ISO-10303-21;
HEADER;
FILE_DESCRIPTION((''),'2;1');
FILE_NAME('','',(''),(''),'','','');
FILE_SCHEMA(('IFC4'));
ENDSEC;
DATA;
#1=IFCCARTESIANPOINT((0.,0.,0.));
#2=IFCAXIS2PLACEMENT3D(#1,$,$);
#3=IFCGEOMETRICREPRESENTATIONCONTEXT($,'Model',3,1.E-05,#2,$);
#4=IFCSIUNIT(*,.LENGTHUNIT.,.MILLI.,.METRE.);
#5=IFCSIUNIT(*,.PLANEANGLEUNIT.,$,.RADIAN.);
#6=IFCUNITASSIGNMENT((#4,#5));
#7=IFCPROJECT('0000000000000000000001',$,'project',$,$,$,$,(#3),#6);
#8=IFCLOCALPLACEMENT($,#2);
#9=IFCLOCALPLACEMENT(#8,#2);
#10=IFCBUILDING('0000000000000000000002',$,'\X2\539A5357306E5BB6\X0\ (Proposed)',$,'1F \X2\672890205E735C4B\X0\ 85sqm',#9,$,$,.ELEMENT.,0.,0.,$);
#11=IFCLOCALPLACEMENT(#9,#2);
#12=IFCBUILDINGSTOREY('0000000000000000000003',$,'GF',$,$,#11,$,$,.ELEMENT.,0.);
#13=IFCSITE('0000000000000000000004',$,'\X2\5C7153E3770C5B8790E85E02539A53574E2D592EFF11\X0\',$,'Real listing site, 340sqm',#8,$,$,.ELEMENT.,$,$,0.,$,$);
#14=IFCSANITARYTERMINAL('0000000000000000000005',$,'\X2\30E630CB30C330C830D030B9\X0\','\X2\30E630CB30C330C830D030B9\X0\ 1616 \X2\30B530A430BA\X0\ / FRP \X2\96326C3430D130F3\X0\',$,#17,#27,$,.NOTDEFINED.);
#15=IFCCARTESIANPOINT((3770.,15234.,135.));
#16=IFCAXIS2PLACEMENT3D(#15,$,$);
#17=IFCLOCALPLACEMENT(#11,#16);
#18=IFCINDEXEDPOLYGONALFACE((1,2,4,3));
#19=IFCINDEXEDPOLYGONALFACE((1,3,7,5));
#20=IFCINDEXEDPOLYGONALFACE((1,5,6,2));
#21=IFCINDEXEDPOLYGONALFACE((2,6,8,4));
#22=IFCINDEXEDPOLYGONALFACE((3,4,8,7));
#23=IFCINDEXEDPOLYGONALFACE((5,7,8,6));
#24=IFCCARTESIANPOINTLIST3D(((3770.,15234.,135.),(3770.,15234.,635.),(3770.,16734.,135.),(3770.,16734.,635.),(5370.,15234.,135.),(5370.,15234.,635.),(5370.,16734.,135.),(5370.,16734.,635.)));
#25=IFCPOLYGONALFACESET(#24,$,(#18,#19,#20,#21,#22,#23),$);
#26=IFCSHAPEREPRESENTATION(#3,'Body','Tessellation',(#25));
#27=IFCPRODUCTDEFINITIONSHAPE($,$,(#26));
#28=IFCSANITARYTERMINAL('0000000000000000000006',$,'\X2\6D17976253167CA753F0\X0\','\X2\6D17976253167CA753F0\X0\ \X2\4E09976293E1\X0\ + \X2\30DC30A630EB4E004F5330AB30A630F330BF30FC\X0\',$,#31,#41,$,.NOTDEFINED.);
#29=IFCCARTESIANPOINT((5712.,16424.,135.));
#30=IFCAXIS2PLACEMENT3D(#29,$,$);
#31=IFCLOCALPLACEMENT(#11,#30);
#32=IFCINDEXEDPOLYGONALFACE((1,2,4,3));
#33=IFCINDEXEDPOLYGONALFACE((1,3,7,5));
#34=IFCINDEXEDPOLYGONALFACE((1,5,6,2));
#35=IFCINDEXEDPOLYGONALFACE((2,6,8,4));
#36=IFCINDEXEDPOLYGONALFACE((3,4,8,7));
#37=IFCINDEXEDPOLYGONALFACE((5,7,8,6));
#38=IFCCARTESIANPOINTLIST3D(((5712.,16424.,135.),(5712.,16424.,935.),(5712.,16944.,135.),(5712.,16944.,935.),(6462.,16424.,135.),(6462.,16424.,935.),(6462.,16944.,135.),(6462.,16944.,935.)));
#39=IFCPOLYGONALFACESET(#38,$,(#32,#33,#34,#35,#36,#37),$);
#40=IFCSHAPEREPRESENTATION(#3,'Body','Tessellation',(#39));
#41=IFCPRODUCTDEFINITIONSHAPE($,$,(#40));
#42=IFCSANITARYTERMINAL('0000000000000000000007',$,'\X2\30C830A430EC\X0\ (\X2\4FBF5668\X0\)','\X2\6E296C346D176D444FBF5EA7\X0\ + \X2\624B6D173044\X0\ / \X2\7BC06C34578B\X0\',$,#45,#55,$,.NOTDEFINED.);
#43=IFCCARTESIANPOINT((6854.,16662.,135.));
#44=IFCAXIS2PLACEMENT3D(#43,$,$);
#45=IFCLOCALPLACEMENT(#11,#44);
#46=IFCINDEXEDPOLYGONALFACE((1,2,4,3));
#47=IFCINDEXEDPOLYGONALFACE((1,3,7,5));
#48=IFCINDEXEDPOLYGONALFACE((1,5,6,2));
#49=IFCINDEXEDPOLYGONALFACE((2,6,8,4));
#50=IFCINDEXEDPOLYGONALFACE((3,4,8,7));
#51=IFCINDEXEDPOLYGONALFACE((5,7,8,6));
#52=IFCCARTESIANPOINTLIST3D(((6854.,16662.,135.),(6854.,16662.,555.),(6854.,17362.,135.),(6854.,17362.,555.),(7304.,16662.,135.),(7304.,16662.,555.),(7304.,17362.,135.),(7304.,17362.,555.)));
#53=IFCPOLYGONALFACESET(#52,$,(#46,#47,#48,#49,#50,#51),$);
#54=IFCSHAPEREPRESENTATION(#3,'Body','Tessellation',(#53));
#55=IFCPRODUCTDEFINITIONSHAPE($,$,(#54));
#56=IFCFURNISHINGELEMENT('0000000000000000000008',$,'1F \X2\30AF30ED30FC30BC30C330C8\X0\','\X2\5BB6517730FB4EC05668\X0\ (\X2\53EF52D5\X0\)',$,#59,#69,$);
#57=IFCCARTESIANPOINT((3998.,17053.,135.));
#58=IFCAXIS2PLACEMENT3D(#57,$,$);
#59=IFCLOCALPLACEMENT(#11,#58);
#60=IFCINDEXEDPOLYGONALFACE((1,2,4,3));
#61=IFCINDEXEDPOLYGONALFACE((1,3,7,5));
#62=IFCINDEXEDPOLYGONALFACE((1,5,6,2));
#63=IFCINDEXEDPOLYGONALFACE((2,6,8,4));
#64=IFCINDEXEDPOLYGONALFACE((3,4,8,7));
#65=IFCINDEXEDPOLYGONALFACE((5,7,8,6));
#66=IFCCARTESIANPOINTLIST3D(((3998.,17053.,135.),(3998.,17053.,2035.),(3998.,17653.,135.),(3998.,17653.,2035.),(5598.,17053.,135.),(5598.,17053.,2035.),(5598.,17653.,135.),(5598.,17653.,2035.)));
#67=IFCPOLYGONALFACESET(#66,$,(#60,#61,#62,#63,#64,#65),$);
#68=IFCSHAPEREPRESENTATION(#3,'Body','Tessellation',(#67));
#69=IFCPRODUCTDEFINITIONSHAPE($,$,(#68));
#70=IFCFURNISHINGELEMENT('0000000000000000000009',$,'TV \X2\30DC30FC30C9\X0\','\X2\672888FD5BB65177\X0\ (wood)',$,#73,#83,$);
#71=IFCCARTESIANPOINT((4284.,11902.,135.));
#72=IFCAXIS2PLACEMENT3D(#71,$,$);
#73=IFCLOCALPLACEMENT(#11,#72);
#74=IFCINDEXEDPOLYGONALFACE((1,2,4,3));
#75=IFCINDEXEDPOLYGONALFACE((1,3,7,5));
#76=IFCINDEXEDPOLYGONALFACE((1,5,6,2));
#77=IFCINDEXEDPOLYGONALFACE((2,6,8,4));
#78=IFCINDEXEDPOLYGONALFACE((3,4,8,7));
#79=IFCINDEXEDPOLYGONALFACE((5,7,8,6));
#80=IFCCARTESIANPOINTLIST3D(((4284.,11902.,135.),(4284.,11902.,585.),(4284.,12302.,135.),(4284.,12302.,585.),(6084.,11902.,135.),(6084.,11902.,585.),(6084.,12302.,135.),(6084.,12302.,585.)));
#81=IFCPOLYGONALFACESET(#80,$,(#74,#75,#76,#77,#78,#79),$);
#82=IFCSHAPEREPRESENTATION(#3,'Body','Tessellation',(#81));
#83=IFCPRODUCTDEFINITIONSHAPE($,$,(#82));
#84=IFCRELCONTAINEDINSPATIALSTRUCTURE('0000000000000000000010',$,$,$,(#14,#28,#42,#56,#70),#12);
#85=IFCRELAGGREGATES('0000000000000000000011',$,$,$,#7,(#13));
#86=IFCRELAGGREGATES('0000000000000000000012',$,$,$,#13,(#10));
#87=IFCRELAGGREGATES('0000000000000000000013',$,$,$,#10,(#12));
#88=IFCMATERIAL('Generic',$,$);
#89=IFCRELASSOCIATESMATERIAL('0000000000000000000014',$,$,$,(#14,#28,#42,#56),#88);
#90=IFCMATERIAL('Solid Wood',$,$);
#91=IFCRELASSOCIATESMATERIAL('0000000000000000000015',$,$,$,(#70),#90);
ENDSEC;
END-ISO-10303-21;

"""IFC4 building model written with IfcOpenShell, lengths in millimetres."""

from ifc_helpers import new_model, si_unit, frame, frame_2d, origin, place, context, project, spatial, rectangle, extrude, material, element, save


model = new_model("IFC4")

# Units and contexts
model_context = context("Model", 3, precision=1e-05, world=origin())
ifc_project = project(units=[si_unit("LENGTHUNIT", "METRE", prefix="MILLI"), si_unit("PLANEANGLEUNIT", "RADIAN")], contexts=[model_context])

# Site, building, storey
site_placement = place(None, origin())
site = spatial("IfcSite", under=ifc_project, at=site_placement, Name="山口県宇部市厚南中央１", ObjectType="Real listing site, 340sqm", CompositionType="ELEMENT", RefElevation=0.0)
building_placement = place(site_placement, origin())
building = spatial("IfcBuilding", under=site, at=building_placement, Name="厚南の家 (Proposed)", ObjectType="1F 木造平屋 85sqm", CompositionType="ELEMENT", ElevationOfRefHeight=0.0, ElevationOfTerrain=0.0)
storey_placement = place(building_placement, origin())
storey = spatial("IfcBuildingStorey", under=building, at=storey_placement, Name="GF", CompositionType="ELEMENT", Elevation=0.0)

# Shared definitions
ifc_material_1 = material(Name="Solid Wood")

# Shared definitions
ifc_material_2 = material(Name="Generic")

# Sanitary terminals
sanitary_terminal_1_placement = place(storey_placement, frame((3770.0, 15234.0, 135.0)))
element("IfcSanitaryTerminal", 1, at=sanitary_terminal_1_placement, inside=storey, material=ifc_material_2, Name="ユニットバス", Description="ユニットバス 1616 サイズ / FRP 防水パン", PredefinedType="NOTDEFINED", context=model_context, shape_type="SweptSolid", body=[
    extrude(rectangle(XDim=1600.0, YDim=1500.0, at=frame_2d((800.0, 750.0))), frame((3770.0, 15234.0, 135.0)), (0.0, 0.0, 1.0), 500.0),
])
sanitary_terminal_2_placement = place(storey_placement, frame((5712.0, 16424.0, 135.0)))
element("IfcSanitaryTerminal", 2, at=sanitary_terminal_2_placement, inside=storey, material=ifc_material_2, Name="洗面化粧台", Description="洗面化粧台 三面鏡 + ボウル一体カウンター", PredefinedType="NOTDEFINED", context=model_context, shape_type="SweptSolid", body=[
    extrude(rectangle(XDim=750.0, YDim=520.0, at=frame_2d((375.0, 260.0))), frame((5712.0, 16424.0, 135.0)), (0.0, 0.0, 1.0), 800.0),
])
sanitary_terminal_3_placement = place(storey_placement, frame((6854.0, 16662.0, 135.0)))
element("IfcSanitaryTerminal", 3, at=sanitary_terminal_3_placement, inside=storey, material=ifc_material_2, Name="トイレ (便器)", Description="温水洗浄便座 + 手洗い / 節水型", PredefinedType="NOTDEFINED", context=model_context, shape_type="SweptSolid", body=[
    extrude(rectangle(XDim=450.0, YDim=700.0, at=frame_2d((225.0, 350.0))), frame((6854.0, 16662.0, 135.0)), (0.0, 0.0, 1.0), 420.0),
])

# Furnishing elements
furnishing_1_placement = place(storey_placement, frame((3998.0, 17053.0, 135.0)))
element("IfcFurnishingElement", 4, at=furnishing_1_placement, inside=storey, material=ifc_material_2, Name="1F クローゼット", Description="家具・什器 (可動)", context=model_context, shape_type="SweptSolid", body=[
    extrude(rectangle(XDim=1600.0, YDim=600.0, at=frame_2d((800.0, 300.0))), frame((3998.0, 17053.0, 135.0)), (0.0, 0.0, 1.0), 1900.0),
])
furnishing_2_placement = place(storey_placement, frame((4284.0, 11902.0, 135.0)))
element("IfcFurnishingElement", 5, at=furnishing_2_placement, inside=storey, material=ifc_material_1, Name="TV ボード", Description="木製家具 (wood)", context=model_context, shape_type="SweptSolid", body=[
    extrude(rectangle(XDim=1800.0, YDim=400.0, at=frame_2d((900.0, 200.0))), frame((4284.0, 11902.0, 135.0)), (0.0, 0.0, 1.0), 450.0),
])

save(model, "model.ifc")
